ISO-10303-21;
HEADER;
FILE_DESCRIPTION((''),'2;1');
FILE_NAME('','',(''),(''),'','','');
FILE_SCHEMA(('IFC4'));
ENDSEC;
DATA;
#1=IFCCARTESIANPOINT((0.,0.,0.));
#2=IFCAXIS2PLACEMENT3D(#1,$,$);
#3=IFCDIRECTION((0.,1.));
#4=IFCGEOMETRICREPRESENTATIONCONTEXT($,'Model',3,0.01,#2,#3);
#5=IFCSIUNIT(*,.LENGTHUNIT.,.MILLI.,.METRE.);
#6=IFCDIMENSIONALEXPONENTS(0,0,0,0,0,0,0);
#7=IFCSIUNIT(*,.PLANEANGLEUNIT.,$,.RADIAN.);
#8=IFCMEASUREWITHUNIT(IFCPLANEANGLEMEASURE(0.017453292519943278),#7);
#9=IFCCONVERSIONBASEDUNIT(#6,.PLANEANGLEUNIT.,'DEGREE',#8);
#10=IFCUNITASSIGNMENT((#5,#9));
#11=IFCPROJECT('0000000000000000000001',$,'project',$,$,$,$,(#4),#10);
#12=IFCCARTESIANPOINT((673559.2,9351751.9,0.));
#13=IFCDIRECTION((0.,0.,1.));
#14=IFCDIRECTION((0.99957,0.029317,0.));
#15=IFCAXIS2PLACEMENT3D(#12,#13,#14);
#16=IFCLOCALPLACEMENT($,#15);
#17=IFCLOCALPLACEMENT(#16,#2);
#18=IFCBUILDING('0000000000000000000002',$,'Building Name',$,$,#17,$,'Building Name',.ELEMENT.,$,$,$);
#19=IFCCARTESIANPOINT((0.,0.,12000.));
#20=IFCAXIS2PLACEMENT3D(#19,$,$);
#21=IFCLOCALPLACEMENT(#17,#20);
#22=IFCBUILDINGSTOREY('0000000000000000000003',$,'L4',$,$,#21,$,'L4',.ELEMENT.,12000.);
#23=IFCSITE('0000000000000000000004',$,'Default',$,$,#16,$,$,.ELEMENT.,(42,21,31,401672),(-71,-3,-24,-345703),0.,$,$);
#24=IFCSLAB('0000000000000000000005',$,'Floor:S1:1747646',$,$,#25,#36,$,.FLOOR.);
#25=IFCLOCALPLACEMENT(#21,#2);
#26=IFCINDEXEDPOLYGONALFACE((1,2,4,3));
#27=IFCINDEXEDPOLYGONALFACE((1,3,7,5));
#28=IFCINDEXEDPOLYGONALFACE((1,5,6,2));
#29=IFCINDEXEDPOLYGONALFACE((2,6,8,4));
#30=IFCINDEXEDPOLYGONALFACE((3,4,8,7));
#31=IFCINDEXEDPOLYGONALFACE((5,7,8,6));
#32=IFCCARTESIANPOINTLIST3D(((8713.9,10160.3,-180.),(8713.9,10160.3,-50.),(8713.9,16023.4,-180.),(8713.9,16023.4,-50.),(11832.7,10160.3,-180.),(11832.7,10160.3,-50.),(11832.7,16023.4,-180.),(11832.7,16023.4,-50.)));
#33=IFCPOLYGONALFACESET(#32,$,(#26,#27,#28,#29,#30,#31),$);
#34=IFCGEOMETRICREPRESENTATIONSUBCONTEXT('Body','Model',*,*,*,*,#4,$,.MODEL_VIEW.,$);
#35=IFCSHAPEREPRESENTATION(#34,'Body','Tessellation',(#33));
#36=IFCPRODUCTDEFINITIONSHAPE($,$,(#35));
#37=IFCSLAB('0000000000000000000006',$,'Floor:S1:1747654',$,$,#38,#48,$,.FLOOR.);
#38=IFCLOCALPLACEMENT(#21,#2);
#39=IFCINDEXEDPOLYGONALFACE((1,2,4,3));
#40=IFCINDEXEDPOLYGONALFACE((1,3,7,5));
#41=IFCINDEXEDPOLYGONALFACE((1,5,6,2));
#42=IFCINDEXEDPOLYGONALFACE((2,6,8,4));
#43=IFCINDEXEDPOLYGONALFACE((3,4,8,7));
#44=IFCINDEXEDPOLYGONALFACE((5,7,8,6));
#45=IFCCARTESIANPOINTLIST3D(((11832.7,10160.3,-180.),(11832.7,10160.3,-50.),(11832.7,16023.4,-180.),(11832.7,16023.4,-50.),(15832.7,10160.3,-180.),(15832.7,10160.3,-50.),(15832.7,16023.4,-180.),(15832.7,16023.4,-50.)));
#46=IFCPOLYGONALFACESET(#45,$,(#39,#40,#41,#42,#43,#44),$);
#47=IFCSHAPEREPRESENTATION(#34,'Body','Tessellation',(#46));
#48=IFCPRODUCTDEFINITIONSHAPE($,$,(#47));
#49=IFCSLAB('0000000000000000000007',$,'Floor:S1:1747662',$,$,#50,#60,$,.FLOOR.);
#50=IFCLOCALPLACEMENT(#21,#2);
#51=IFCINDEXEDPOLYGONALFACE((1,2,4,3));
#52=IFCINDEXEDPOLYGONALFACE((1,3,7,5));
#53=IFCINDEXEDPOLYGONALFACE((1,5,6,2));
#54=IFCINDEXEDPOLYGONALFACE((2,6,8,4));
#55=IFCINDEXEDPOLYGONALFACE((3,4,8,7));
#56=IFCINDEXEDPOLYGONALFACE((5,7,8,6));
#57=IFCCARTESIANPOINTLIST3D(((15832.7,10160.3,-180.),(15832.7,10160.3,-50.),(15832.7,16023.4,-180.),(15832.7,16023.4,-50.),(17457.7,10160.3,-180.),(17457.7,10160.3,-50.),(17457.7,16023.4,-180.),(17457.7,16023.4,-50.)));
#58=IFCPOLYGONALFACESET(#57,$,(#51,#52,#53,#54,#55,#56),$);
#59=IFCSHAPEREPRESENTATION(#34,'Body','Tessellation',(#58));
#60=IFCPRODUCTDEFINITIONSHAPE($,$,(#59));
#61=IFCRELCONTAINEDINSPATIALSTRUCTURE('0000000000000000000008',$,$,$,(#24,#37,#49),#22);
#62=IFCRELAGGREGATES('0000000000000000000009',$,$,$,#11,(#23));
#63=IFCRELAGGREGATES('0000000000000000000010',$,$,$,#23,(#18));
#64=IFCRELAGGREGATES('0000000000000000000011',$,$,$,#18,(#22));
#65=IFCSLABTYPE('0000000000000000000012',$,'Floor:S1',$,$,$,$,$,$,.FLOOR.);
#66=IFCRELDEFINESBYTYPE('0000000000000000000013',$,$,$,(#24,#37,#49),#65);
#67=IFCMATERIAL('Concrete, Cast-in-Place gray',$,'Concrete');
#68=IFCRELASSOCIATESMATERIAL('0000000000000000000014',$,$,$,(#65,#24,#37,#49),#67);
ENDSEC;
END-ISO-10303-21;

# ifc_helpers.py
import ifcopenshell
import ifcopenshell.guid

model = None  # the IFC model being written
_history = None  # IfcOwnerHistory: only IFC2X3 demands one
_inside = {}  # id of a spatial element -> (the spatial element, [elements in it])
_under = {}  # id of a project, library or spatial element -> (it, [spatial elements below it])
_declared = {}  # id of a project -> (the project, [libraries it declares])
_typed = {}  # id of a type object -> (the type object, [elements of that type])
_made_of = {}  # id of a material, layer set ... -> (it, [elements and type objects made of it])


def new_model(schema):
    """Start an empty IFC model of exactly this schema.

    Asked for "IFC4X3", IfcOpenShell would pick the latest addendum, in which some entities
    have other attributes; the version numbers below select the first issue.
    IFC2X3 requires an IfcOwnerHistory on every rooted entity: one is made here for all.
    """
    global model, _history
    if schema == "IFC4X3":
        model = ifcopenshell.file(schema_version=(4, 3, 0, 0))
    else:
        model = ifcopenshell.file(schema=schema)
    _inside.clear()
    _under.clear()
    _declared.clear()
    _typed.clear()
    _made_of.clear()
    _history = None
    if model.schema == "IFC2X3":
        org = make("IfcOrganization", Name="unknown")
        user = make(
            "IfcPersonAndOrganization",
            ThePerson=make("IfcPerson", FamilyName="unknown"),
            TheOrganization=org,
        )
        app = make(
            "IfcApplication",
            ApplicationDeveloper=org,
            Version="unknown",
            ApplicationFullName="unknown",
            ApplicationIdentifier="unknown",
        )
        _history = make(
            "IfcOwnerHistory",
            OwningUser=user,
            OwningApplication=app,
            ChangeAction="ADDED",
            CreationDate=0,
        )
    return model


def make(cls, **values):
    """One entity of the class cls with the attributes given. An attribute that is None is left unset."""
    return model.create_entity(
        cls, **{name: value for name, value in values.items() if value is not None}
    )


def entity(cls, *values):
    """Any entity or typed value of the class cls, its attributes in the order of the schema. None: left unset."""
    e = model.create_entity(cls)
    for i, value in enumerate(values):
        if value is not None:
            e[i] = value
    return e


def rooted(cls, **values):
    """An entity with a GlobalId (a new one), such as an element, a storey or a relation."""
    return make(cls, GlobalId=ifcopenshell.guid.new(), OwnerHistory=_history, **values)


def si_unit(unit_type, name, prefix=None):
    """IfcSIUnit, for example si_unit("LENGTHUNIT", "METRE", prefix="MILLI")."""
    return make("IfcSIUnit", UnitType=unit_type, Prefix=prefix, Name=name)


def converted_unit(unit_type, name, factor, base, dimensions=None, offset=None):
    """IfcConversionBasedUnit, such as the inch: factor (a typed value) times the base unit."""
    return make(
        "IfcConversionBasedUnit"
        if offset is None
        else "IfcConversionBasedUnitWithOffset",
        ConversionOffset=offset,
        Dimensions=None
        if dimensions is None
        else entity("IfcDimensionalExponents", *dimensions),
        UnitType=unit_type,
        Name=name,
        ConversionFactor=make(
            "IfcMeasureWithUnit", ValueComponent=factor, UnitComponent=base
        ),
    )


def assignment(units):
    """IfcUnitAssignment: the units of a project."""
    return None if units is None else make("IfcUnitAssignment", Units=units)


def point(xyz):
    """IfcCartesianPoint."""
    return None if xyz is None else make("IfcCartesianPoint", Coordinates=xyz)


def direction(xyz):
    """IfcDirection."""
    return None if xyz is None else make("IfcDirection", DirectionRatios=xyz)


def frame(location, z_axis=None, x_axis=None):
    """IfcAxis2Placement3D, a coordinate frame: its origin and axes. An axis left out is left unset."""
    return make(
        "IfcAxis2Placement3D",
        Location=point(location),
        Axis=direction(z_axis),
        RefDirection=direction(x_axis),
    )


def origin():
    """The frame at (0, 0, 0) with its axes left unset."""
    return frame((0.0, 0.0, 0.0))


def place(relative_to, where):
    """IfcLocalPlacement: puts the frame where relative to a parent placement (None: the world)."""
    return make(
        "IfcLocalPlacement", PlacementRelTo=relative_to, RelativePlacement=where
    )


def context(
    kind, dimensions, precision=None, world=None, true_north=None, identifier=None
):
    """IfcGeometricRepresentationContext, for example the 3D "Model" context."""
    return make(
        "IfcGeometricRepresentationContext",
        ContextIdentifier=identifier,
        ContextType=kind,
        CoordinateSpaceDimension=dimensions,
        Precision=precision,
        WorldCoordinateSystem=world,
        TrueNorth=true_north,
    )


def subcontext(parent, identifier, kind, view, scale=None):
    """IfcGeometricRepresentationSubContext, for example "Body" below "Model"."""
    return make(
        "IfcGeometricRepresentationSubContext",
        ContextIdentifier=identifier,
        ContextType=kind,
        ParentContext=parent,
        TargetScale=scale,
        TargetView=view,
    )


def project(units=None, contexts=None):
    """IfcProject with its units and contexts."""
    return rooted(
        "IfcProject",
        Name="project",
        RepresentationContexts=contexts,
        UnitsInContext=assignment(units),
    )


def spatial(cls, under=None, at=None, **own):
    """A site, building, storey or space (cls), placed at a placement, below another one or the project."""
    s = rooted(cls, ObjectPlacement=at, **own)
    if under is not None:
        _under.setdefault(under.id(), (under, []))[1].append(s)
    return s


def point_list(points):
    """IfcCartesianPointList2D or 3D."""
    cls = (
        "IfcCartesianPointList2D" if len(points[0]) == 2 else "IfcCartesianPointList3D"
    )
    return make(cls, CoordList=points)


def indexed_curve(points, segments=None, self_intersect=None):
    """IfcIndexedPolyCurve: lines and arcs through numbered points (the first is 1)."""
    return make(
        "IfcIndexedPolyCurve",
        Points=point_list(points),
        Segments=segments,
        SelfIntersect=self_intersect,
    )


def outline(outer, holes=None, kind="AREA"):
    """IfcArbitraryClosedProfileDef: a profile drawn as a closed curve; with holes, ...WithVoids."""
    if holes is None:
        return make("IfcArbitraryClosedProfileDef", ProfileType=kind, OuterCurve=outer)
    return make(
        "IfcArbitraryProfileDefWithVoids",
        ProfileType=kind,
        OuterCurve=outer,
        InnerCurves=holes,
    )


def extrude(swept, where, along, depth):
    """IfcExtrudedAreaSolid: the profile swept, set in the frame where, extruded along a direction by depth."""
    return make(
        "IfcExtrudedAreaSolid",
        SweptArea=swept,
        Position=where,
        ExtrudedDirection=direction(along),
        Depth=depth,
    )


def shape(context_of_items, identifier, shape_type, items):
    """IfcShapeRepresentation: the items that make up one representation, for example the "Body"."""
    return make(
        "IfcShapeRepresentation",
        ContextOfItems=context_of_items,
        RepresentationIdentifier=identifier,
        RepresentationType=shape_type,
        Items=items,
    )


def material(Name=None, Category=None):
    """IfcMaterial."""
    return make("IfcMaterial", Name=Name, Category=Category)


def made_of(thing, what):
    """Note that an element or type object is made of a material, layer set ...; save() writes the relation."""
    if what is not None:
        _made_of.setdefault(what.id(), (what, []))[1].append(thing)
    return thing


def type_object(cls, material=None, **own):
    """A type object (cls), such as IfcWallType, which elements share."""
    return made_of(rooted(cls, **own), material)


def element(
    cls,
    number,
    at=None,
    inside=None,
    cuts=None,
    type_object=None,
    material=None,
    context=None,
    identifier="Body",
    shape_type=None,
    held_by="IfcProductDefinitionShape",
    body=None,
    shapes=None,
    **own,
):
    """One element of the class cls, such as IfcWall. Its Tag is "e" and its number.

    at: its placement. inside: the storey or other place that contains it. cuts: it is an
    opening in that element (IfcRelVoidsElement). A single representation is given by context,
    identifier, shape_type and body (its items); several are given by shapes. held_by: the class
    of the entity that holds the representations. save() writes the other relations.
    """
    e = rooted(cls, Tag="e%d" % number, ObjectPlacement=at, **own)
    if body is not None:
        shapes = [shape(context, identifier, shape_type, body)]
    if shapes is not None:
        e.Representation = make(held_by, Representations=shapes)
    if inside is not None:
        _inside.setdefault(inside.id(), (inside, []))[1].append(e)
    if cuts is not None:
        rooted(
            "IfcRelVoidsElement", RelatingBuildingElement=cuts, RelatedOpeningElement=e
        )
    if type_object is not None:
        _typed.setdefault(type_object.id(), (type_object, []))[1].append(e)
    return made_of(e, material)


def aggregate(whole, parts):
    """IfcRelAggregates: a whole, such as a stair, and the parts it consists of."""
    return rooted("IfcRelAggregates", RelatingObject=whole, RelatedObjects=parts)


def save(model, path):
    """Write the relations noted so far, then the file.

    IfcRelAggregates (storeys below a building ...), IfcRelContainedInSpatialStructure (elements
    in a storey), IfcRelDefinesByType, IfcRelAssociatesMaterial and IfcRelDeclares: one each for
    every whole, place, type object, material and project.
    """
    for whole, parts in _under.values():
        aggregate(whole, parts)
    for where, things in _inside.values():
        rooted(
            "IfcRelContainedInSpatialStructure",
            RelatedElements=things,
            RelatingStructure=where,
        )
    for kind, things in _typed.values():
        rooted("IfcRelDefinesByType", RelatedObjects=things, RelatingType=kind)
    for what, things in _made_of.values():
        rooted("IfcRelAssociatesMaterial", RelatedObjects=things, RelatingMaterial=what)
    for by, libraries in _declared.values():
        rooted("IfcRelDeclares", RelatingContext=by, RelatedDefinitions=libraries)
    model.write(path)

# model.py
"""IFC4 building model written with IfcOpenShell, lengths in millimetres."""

from ifc_helpers import new_model, entity, si_unit, converted_unit, direction, frame, origin, place, context, subcontext, project, spatial, indexed_curve, outline, extrude, material, type_object, element, save


model = new_model("IFC4")

# Units and contexts
model_context = context("Model", 3, precision=0.01, world=origin(), true_north=direction((0.0, 1.0)))
body_context = subcontext(model_context, "Body", "Model", "MODEL_VIEW")
ifc_project = project(units=[si_unit("LENGTHUNIT", "METRE", prefix="MILLI"), converted_unit("PLANEANGLEUNIT", "DEGREE", entity("IfcPlaneAngleMeasure", 0.017453292519943278), si_unit("PLANEANGLEUNIT", "RADIAN"), dimensions=[0, 0, 0, 0, 0, 0, 0])], contexts=[model_context])

# Site, building, storey
site_placement = place(None, frame((673559.2, 9351751.9, 0.0), z_axis=(0.0, 0.0, 1.0), x_axis=(0.99957, 0.029317, 0.0)))
site = spatial("IfcSite", under=ifc_project, at=site_placement, Name="Default", CompositionType="ELEMENT", RefLatitude=(42, 21, 31, 401672), RefLongitude=(-71, -3, -24, -345703), RefElevation=0.0)
building_placement = place(site_placement, origin())
building = spatial("IfcBuilding", under=site, at=building_placement, Name="Building Name", LongName="Building Name", CompositionType="ELEMENT")
storey_placement = place(building_placement, frame((0.0, 0.0, 12000.0)))
storey = spatial("IfcBuildingStorey", under=building, at=storey_placement, Name="L4", LongName="L4", CompositionType="ELEMENT", Elevation=12000.0)

# Shared definitions
ifc_material_1 = material(Name="Concrete, Cast-in-Place gray", Category="Concrete")

# Slabs
slab_type_1 = type_object("IfcSlabType", Name="Floor:S1", PredefinedType="FLOOR", material=ifc_material_1)
slab_1_placement = place(storey_placement, origin())
element("IfcSlab", 1, at=slab_1_placement, inside=storey, type_object=slab_type_1, material=ifc_material_1, Name="Floor:S1:1747646", PredefinedType="FLOOR", context=body_context, shape_type="SweptSolid", body=[
    extrude(outline(indexed_curve([(-2931.5, -1559.4), (2931.5, -1559.4), (2931.5, 1559.4), (-2931.5, 1559.4), (-2931.5, -1559.4)], self_intersect=False)), frame((10273.3, 13091.8, -50.0), z_axis=(0.0, 0.0, -1.0), x_axis=(0.0, 1.0, 0.0)), (0.0, 0.0, 1.0), 130.0),
])
slab_2_placement = place(storey_placement, origin())
element("IfcSlab", 2, at=slab_2_placement, inside=storey, type_object=slab_type_1, material=ifc_material_1, Name="Floor:S1:1747654", PredefinedType="FLOOR", context=body_context, shape_type="SweptSolid", body=[
    extrude(outline(indexed_curve([(-2931.5, -2000.0), (2931.5, -2000.0), (2931.5, 2000.0), (-2931.5, 2000.0), (-2931.5, -2000.0)], self_intersect=False)), frame((13832.7, 13091.8, -50.0), z_axis=(0.0, 0.0, -1.0), x_axis=(0.0, 1.0, 0.0)), (0.0, 0.0, 1.0), 130.0),
])
slab_3_placement = place(storey_placement, origin())
element("IfcSlab", 3, at=slab_3_placement, inside=storey, type_object=slab_type_1, material=ifc_material_1, Name="Floor:S1:1747662", PredefinedType="FLOOR", context=body_context, shape_type="SweptSolid", body=[
    extrude(outline(indexed_curve([(-2931.5, -812.5), (2931.5, -812.5), (2931.5, 812.5), (-2931.5, 812.5), (-2931.5, -812.5)], self_intersect=False)), frame((16645.2, 13091.8, -50.0), z_axis=(0.0, 0.0, -1.0), x_axis=(0.0, 1.0, 0.0)), (0.0, 0.0, 1.0), 130.0),
])

save(model, "model.ifc")
